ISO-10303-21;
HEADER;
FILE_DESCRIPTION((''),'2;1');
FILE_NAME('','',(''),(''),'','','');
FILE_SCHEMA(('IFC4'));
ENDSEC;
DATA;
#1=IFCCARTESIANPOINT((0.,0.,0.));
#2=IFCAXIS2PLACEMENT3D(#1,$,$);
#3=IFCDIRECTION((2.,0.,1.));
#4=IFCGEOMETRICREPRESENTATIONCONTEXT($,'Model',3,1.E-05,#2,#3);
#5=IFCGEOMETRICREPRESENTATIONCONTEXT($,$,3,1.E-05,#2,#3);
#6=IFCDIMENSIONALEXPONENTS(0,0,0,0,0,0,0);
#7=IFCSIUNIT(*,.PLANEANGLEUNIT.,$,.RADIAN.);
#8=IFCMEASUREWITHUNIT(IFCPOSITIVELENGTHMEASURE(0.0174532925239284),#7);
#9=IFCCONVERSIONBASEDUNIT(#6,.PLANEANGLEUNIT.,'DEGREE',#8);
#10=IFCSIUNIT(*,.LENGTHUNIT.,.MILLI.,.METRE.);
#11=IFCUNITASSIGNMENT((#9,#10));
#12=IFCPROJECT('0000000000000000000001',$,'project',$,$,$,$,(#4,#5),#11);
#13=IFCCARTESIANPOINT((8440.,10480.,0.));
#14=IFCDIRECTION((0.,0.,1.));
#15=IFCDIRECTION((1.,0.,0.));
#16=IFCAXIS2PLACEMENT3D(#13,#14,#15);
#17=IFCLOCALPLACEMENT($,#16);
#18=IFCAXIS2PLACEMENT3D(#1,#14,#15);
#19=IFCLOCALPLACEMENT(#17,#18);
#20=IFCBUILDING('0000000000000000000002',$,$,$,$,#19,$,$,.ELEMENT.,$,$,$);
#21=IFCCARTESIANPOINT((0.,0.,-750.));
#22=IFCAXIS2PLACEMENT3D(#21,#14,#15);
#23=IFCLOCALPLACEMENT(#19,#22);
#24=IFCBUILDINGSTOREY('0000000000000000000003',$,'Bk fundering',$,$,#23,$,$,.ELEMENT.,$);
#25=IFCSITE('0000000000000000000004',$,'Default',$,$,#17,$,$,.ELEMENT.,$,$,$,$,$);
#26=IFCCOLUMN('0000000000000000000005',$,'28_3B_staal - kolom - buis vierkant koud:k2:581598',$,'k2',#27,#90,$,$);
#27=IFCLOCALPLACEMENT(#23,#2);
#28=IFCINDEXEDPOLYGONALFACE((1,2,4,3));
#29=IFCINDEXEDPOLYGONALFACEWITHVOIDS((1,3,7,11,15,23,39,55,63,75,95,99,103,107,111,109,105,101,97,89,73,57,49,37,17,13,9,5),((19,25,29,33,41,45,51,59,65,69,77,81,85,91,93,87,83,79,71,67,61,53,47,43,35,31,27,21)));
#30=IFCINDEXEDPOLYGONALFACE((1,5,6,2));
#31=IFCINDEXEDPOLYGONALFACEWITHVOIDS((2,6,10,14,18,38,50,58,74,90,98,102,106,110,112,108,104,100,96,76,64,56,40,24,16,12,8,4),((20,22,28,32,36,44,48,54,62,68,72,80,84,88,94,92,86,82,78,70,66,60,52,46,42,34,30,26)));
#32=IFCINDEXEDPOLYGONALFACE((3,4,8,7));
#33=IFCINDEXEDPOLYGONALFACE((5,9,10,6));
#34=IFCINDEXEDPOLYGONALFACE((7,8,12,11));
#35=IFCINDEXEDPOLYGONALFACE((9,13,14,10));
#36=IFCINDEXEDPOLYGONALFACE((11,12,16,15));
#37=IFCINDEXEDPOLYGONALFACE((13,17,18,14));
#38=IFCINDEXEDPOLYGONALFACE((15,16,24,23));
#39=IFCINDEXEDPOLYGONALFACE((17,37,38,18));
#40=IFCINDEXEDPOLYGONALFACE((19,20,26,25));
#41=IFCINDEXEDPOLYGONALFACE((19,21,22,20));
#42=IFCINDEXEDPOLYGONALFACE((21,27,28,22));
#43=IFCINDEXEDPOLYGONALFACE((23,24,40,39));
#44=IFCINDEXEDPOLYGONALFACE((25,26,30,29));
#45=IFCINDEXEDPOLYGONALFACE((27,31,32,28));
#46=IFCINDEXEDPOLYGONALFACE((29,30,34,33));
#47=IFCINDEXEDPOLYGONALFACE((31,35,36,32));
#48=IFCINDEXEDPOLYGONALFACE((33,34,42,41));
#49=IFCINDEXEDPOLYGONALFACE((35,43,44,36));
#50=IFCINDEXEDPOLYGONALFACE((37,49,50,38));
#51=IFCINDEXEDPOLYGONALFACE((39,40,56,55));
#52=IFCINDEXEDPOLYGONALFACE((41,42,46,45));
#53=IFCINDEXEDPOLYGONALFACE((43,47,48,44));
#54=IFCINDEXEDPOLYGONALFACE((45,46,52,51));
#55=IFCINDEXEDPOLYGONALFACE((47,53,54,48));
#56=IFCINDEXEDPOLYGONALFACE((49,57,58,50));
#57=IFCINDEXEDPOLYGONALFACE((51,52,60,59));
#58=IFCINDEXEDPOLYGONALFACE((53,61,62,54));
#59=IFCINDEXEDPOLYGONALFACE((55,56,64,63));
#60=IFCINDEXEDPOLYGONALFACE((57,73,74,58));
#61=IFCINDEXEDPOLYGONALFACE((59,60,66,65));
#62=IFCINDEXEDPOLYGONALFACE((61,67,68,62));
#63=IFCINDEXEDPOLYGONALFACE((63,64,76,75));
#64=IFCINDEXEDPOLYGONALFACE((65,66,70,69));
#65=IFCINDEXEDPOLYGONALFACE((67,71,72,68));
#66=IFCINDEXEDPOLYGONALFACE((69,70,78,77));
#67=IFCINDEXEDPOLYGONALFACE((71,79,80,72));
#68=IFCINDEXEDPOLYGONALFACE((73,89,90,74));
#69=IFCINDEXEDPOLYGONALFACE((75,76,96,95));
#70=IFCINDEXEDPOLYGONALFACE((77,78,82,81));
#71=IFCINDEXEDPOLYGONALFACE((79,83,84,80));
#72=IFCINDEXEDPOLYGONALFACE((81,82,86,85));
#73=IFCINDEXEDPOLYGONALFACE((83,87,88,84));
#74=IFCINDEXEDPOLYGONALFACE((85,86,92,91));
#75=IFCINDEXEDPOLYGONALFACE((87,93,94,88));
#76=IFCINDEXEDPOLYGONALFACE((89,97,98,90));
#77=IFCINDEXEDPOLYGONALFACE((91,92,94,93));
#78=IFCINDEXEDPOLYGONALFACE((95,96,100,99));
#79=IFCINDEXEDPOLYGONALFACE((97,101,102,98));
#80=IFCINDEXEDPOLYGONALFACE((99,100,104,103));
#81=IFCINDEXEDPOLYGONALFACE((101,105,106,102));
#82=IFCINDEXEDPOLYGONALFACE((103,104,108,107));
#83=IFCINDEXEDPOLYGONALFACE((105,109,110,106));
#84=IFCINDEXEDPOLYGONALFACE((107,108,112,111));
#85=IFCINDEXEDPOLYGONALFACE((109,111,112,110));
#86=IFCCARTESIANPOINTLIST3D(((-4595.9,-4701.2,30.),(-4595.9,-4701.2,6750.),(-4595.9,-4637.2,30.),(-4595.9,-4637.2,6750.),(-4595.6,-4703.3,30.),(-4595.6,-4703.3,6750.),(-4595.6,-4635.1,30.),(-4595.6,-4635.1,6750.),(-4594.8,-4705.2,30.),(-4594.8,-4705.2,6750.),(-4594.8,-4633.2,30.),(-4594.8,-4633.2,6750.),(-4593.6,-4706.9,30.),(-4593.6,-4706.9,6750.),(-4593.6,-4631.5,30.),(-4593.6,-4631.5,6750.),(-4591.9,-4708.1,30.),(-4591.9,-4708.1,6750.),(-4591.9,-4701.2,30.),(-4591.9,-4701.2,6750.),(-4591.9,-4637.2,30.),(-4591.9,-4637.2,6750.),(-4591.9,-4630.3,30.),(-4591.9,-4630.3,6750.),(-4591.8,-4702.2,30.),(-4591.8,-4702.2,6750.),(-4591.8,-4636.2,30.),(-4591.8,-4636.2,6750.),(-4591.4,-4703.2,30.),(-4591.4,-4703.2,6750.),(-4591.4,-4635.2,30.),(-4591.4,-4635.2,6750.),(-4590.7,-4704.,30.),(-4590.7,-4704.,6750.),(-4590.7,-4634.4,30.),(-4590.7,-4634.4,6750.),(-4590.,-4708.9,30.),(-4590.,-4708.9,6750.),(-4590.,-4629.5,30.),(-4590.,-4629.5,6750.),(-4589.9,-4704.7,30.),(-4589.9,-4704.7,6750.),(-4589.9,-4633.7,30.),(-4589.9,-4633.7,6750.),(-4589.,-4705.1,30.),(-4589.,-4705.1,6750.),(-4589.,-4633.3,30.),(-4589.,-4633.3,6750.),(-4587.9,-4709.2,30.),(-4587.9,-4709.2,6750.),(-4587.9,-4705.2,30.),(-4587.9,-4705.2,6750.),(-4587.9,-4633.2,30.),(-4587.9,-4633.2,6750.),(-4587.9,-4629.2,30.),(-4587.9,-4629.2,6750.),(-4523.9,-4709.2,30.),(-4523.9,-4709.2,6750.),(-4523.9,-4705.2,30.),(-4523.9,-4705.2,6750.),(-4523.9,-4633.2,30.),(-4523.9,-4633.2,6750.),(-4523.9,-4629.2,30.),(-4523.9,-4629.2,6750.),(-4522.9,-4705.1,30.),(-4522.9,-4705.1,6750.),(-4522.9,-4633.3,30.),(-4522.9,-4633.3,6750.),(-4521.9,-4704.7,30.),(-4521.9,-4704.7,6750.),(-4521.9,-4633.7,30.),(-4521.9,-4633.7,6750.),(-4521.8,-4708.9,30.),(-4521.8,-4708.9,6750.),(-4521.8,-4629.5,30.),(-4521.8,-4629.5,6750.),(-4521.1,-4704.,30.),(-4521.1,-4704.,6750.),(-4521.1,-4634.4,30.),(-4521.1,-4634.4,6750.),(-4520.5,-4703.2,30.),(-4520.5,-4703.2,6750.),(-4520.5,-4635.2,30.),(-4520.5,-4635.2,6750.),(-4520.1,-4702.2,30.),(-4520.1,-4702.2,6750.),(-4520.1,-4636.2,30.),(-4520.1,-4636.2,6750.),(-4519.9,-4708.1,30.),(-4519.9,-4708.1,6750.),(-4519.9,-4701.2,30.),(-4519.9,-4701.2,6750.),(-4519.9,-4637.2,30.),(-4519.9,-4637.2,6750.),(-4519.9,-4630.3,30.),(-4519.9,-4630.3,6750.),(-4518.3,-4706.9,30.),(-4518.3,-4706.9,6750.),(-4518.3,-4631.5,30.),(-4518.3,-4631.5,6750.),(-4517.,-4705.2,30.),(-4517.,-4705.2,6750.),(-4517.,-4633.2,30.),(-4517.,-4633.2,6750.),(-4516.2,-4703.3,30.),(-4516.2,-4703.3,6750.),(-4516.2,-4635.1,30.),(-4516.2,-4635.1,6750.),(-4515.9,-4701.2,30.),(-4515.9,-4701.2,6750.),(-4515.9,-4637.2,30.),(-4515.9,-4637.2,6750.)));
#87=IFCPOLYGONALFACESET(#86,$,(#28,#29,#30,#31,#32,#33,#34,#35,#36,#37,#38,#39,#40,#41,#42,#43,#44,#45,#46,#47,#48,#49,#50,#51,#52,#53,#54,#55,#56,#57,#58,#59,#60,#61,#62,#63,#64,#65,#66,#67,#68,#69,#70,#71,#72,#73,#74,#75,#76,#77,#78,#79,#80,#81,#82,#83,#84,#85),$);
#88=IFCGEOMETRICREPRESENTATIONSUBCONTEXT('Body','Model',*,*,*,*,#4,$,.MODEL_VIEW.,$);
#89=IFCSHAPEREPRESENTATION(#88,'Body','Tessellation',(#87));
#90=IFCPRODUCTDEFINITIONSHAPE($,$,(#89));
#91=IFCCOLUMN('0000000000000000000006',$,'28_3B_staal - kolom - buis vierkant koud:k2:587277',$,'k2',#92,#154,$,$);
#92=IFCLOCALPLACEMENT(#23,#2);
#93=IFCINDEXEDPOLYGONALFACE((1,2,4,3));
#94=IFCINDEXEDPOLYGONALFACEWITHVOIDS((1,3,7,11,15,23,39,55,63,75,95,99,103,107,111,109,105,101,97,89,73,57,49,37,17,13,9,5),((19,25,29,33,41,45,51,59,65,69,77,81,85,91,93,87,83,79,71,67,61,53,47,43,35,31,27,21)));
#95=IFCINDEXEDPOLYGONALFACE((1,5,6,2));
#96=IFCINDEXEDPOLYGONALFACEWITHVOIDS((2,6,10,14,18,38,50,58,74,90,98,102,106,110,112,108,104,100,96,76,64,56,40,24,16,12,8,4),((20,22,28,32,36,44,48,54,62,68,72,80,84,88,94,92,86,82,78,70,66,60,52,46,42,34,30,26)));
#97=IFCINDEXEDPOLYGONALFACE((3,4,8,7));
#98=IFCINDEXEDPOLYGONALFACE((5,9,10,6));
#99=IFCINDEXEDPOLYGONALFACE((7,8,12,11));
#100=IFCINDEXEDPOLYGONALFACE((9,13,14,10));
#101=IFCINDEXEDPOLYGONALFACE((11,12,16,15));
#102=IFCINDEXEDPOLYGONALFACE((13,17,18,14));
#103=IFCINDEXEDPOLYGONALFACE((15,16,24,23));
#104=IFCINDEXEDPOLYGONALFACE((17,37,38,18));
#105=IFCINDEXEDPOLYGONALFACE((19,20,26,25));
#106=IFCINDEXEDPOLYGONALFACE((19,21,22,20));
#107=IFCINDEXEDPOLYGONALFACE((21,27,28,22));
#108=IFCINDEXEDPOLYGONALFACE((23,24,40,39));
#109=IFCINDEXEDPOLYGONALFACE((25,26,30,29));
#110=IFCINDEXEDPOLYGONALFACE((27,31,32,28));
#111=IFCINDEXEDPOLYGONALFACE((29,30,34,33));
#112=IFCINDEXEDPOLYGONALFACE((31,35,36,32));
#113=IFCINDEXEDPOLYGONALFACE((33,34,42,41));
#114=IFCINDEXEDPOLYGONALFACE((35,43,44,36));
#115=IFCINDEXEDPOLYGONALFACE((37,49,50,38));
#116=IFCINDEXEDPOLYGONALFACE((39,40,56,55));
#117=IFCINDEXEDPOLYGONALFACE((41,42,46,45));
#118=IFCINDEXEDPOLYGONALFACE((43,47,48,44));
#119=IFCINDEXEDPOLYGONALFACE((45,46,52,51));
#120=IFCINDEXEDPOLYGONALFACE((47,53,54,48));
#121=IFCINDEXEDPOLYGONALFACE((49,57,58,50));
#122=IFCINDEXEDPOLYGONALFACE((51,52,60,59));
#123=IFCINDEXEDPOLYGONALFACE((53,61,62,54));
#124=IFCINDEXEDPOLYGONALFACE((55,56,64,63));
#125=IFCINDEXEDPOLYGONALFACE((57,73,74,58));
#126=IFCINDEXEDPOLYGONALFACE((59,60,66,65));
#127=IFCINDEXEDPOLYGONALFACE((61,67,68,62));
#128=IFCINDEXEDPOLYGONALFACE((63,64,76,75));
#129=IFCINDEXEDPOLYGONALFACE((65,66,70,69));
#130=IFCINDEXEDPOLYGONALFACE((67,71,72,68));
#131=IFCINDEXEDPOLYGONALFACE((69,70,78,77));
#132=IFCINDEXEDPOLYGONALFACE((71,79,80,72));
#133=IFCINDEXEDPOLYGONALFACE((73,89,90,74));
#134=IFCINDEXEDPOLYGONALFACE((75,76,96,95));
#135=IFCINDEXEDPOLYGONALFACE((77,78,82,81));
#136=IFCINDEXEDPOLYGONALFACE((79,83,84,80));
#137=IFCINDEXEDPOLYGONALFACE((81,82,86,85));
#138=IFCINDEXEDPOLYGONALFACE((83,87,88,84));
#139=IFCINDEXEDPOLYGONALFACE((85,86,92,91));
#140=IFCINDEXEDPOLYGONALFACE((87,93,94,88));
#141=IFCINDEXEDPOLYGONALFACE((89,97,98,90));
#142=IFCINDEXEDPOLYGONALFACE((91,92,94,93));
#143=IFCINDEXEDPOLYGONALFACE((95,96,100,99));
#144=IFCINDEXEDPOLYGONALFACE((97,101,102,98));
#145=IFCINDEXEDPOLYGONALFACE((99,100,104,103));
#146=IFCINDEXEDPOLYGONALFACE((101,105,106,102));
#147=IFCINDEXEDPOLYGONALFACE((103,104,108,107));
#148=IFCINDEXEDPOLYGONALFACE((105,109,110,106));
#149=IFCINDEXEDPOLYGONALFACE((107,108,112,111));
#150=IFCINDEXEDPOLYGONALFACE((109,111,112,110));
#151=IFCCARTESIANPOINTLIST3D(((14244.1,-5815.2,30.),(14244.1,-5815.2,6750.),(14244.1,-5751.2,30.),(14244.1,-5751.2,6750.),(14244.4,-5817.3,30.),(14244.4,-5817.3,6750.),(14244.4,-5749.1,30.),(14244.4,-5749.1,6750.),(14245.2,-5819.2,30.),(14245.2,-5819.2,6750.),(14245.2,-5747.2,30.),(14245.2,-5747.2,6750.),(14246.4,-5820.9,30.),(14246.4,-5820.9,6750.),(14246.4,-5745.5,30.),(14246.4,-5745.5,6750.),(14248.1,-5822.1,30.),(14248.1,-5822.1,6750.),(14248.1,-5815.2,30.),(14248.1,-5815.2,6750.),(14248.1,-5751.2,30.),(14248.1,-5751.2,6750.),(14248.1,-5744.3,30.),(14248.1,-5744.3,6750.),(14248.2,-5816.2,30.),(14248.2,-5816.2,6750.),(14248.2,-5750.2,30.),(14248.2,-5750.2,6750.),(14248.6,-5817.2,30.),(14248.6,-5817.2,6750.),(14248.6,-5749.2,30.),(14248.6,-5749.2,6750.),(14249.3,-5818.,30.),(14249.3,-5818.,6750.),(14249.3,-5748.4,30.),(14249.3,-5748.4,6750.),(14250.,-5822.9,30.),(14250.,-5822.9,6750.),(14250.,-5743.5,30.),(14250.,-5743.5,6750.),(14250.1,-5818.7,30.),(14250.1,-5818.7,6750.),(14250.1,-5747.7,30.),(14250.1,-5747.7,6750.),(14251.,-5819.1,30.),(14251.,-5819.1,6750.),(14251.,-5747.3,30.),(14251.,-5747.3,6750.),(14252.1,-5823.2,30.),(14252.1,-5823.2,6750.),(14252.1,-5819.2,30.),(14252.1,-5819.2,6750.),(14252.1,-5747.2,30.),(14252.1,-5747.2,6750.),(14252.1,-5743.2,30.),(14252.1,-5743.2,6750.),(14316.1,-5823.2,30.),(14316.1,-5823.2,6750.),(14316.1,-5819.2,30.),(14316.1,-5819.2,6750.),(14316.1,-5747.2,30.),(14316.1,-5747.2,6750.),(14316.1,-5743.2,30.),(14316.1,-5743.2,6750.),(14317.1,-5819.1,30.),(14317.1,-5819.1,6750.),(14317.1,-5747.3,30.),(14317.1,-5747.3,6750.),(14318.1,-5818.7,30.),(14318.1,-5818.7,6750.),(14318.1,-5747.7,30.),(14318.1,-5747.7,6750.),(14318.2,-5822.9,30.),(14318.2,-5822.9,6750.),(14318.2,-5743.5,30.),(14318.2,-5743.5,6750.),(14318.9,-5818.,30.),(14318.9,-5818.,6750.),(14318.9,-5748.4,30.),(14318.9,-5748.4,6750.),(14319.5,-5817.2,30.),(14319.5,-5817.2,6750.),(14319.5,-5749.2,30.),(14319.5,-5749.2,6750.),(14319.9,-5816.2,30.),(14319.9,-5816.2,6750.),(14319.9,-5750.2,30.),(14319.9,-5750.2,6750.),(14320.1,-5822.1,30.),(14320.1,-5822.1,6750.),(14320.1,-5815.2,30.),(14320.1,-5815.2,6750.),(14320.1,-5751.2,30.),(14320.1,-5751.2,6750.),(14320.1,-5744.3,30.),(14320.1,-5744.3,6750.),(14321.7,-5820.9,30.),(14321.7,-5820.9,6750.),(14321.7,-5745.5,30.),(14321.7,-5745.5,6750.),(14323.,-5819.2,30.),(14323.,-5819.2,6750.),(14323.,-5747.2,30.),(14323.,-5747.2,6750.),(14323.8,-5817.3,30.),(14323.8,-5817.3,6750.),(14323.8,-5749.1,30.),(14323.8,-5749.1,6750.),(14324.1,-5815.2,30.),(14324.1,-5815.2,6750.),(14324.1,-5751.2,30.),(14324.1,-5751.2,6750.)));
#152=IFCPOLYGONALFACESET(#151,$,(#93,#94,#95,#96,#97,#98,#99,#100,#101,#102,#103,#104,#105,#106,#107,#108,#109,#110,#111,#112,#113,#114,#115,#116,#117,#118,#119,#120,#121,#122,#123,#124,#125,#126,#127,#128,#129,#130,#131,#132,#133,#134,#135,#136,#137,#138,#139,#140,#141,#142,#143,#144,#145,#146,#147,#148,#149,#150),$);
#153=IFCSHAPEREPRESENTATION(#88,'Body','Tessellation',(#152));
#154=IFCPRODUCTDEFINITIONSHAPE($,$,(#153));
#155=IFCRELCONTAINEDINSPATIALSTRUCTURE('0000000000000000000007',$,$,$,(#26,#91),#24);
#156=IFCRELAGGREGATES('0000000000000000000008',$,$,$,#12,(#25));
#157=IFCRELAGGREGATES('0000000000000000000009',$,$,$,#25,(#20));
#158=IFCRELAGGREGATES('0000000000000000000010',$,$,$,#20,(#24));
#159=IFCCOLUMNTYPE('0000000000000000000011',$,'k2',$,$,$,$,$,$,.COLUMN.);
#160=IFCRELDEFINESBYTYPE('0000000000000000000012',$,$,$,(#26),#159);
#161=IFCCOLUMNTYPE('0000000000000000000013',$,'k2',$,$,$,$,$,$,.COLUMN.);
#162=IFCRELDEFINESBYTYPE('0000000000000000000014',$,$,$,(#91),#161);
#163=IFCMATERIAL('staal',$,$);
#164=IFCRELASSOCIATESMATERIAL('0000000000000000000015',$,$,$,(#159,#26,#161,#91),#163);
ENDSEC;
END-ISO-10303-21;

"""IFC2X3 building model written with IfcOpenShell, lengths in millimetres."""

from ifc_helpers import new_model, entity, si_unit, converted_unit, direction, frame, frame_2d, origin, origin_with_axes, place, context, subcontext, project, spatial, polyline, circle_curve, parameter, trimmed, segment, composite_curve, outline, extrude, source, transform, mapped, material, type_object, element, save


model = new_model("IFC2X3")

# Units and contexts
model_context = context("Model", 3, precision=1e-05, world=origin(), true_north=direction((2.0, 0.0, 1.0)))
context_of_model = context(None, 3, precision=1e-05, world=origin(), true_north=direction((2.0, 0.0, 1.0)))
body_context = subcontext(model_context, "Body", "Model", "MODEL_VIEW")
ifc_project = project(units=[converted_unit("PLANEANGLEUNIT", "DEGREE", entity("IfcPositiveLengthMeasure", 0.0174532925239284), si_unit("PLANEANGLEUNIT", "RADIAN"), dimensions=[0, 0, 0, 0, 0, 0, 0]), si_unit("LENGTHUNIT", "METRE", prefix="MILLI")], contexts=[model_context, context_of_model])

# Site, building, storey
site_placement = place(None, frame((8440.0, 10480.0, 0.0), z_axis=(0.0, 0.0, 1.0), x_axis=(1.0, 0.0, 0.0)))
site = spatial("IfcSite", under=ifc_project, at=site_placement, Name="Default", CompositionType="ELEMENT")
building_placement = place(site_placement, origin_with_axes())
building = spatial("IfcBuilding", under=site, at=building_placement, CompositionType="ELEMENT")
storey_placement = place(building_placement, frame((0.0, 0.0, -750.0), z_axis=(0.0, 0.0, 1.0), x_axis=(1.0, 0.0, 0.0)))
storey = spatial("IfcBuildingStorey", under=building, at=storey_placement, Name="Bk fundering", CompositionType="ELEMENT")

# Columns
ifc_material_1 = material(Name="staal")
column_type_1 = type_object("IfcColumnType", Name="k2", PredefinedType="COLUMN", material=ifc_material_1)
shared_shape_1 = source(origin(), body_context, "Body", "SweptSolid", [
    extrude(outline(composite_curve([segment(trimmed(circle_curve(frame_2d((32.0, -32.0), x_axis=(1.0, 0.0)), 8.0), [parameter(270.0)], [parameter(0.0)], True, "PARAMETER"), True, "CONTINUOUS"), segment(polyline([(40.0, -32.0), (40.0, 32.0)]), True, "CONTINUOUS"), segment(trimmed(circle_curve(frame_2d((32.0, 32.0), x_axis=(1.0, 0.0)), 8.0), [parameter(0.0)], [parameter(90.0)], True, "PARAMETER"), True, "CONTINUOUS"), segment(polyline([(32.0, 40.0), (-32.0, 40.0)]), True, "CONTINUOUS"), segment(trimmed(circle_curve(frame_2d((-32.0, 32.0), x_axis=(1.0, 0.0)), 8.0), [parameter(90.0)], [parameter(180.0)], True, "PARAMETER"), True, "CONTINUOUS"), segment(polyline([(-40.0, 32.0), (-40.0, -32.0)]), True, "CONTINUOUS"), segment(trimmed(circle_curve(frame_2d((-32.0, -32.0), x_axis=(1.0, 0.0)), 8.0), [parameter(180.0)], [parameter(270.0)], True, "PARAMETER"), True, "CONTINUOUS"), segment(polyline([(-32.0, -40.0), (32.0, -40.0)]), True, "CONTINUOUS")], self_intersect=False), holes=[composite_curve([segment(polyline([(32.0, -36.0), (-32.0, -36.0)]), True, "CONTINUOUS"), segment(trimmed(circle_curve(frame_2d((-32.0, -32.0), x_axis=(1.0, 0.0)), 4.0), [parameter(180.0)], [parameter(270.0)], True, "PARAMETER"), False, "CONTINUOUS"), segment(polyline([(-36.0, -32.0), (-36.0, 32.0)]), True, "CONTINUOUS"), segment(trimmed(circle_curve(frame_2d((-32.0, 32.0), x_axis=(1.0, 0.0)), 4.0), [parameter(90.0)], [parameter(180.0)], True, "PARAMETER"), False, "CONTINUOUS"), segment(polyline([(-32.0, 36.0), (32.0, 36.0)]), True, "CONTINUOUS"), segment(trimmed(circle_curve(frame_2d((32.0, 32.0), x_axis=(1.0, 0.0)), 4.0), [parameter(360.0)], [parameter(90.0)], True, "PARAMETER"), False, "CONTINUOUS"), segment(polyline([(36.0, 32.0), (36.0, -32.0)]), True, "CONTINUOUS"), segment(trimmed(circle_curve(frame_2d((32.0, -32.0), x_axis=(1.0, 0.0)), 4.0), [parameter(270.0)], [parameter(0.0)], True, "PARAMETER"), False, "CONTINUOUS")], self_intersect=False)]), frame((-4555.9, -4669.2, -720.0)), (0.0, 0.0, 1.0), 6720.0),
])
column_1_placement = place(storey_placement, frame((0.0, 0.0, 750.0), z_axis=(0.0, 0.0, 1.0), x_axis=(1.0, 0.0, 0.0)))
element("IfcColumn", 1, at=column_1_placement, inside=storey, type_object=column_type_1, material=ifc_material_1, Name="28_3B_staal - kolom - buis vierkant koud:k2:581598", ObjectType="k2", context=body_context, shape_type="MappedRepresentation", body=[
    mapped(shared_shape_1, transform((0.0, 0.0, 0.0), scale=1.0)),
])
column_type_2 = type_object("IfcColumnType", Name="k2", PredefinedType="COLUMN", material=ifc_material_1)
shared_shape_2 = source(origin(), body_context, "Body", "SweptSolid", [
    extrude(outline(composite_curve([segment(polyline([(-32.0, -40.0), (32.0, -40.0)]), True, "CONTINUOUS"), segment(trimmed(circle_curve(frame_2d((32.0, -32.0), x_axis=(-1.0, 0.0)), 8.0), [parameter(90.0)], [parameter(180.0)], True, "PARAMETER"), True, "CONTINUOUS"), segment(polyline([(40.0, -32.0), (40.0, 32.0)]), True, "CONTINUOUS"), segment(trimmed(circle_curve(frame_2d((32.0, 32.0), x_axis=(-1.0, 0.0)), 8.0), [parameter(180.0)], [parameter(270.0)], True, "PARAMETER"), True, "CONTINUOUS"), segment(polyline([(32.0, 40.0), (-32.0, 40.0)]), True, "CONTINUOUS"), segment(trimmed(circle_curve(frame_2d((-32.0, 32.0), x_axis=(-1.0, 0.0)), 8.0), [parameter(270.0)], [parameter(360.0)], True, "PARAMETER"), True, "CONTINUOUS"), segment(polyline([(-40.0, 32.0), (-40.0, -32.0)]), True, "CONTINUOUS"), segment(trimmed(circle_curve(frame_2d((-32.0, -32.0), x_axis=(-1.0, 0.0)), 8.0), [parameter(360.0)], [parameter(90.0)], True, "PARAMETER"), True, "CONTINUOUS")], self_intersect=False), holes=[composite_curve([segment(trimmed(circle_curve(frame_2d((-32.0, -32.0), x_axis=(-1.0, 0.0)), 4.0), [parameter(0.0)], [parameter(90.0)], True, "PARAMETER"), False, "CONTINUOUS"), segment(polyline([(-36.0, -32.0), (-36.0, 32.0)]), True, "CONTINUOUS"), segment(trimmed(circle_curve(frame_2d((-32.0, 32.0), x_axis=(-1.0, 0.0)), 4.0), [parameter(270.0)], [parameter(0.0)], True, "PARAMETER"), False, "CONTINUOUS"), segment(polyline([(-32.0, 36.0), (32.0, 36.0)]), True, "CONTINUOUS"), segment(trimmed(circle_curve(frame_2d((32.0, 32.0), x_axis=(-1.0, 0.0)), 4.0), [parameter(180.0)], [parameter(270.0)], True, "PARAMETER"), False, "CONTINUOUS"), segment(polyline([(36.0, 32.0), (36.0, -32.0)]), True, "CONTINUOUS"), segment(trimmed(circle_curve(frame_2d((32.0, -32.0), x_axis=(-1.0, 0.0)), 4.0), [parameter(90.0)], [parameter(180.0)], True, "PARAMETER"), False, "CONTINUOUS"), segment(polyline([(32.0, -36.0), (-32.0, -36.0)]), True, "CONTINUOUS")], self_intersect=False)]), frame((14284.1, -5783.2, -720.0)), (0.0, 0.0, 1.0), 6720.0),
])
column_2_placement = place(storey_placement, frame((0.0, 0.0, 750.0), z_axis=(0.0, 0.0, 1.0), x_axis=(1.0, 0.0, 0.0)))
element("IfcColumn", 2, at=column_2_placement, inside=storey, type_object=column_type_2, material=ifc_material_1, Name="28_3B_staal - kolom - buis vierkant koud:k2:587277", ObjectType="k2", context=body_context, shape_type="MappedRepresentation", body=[
    mapped(shared_shape_2, transform((0.0, 0.0, 0.0), scale=1.0)),
])

save(model, "model.ifc")
